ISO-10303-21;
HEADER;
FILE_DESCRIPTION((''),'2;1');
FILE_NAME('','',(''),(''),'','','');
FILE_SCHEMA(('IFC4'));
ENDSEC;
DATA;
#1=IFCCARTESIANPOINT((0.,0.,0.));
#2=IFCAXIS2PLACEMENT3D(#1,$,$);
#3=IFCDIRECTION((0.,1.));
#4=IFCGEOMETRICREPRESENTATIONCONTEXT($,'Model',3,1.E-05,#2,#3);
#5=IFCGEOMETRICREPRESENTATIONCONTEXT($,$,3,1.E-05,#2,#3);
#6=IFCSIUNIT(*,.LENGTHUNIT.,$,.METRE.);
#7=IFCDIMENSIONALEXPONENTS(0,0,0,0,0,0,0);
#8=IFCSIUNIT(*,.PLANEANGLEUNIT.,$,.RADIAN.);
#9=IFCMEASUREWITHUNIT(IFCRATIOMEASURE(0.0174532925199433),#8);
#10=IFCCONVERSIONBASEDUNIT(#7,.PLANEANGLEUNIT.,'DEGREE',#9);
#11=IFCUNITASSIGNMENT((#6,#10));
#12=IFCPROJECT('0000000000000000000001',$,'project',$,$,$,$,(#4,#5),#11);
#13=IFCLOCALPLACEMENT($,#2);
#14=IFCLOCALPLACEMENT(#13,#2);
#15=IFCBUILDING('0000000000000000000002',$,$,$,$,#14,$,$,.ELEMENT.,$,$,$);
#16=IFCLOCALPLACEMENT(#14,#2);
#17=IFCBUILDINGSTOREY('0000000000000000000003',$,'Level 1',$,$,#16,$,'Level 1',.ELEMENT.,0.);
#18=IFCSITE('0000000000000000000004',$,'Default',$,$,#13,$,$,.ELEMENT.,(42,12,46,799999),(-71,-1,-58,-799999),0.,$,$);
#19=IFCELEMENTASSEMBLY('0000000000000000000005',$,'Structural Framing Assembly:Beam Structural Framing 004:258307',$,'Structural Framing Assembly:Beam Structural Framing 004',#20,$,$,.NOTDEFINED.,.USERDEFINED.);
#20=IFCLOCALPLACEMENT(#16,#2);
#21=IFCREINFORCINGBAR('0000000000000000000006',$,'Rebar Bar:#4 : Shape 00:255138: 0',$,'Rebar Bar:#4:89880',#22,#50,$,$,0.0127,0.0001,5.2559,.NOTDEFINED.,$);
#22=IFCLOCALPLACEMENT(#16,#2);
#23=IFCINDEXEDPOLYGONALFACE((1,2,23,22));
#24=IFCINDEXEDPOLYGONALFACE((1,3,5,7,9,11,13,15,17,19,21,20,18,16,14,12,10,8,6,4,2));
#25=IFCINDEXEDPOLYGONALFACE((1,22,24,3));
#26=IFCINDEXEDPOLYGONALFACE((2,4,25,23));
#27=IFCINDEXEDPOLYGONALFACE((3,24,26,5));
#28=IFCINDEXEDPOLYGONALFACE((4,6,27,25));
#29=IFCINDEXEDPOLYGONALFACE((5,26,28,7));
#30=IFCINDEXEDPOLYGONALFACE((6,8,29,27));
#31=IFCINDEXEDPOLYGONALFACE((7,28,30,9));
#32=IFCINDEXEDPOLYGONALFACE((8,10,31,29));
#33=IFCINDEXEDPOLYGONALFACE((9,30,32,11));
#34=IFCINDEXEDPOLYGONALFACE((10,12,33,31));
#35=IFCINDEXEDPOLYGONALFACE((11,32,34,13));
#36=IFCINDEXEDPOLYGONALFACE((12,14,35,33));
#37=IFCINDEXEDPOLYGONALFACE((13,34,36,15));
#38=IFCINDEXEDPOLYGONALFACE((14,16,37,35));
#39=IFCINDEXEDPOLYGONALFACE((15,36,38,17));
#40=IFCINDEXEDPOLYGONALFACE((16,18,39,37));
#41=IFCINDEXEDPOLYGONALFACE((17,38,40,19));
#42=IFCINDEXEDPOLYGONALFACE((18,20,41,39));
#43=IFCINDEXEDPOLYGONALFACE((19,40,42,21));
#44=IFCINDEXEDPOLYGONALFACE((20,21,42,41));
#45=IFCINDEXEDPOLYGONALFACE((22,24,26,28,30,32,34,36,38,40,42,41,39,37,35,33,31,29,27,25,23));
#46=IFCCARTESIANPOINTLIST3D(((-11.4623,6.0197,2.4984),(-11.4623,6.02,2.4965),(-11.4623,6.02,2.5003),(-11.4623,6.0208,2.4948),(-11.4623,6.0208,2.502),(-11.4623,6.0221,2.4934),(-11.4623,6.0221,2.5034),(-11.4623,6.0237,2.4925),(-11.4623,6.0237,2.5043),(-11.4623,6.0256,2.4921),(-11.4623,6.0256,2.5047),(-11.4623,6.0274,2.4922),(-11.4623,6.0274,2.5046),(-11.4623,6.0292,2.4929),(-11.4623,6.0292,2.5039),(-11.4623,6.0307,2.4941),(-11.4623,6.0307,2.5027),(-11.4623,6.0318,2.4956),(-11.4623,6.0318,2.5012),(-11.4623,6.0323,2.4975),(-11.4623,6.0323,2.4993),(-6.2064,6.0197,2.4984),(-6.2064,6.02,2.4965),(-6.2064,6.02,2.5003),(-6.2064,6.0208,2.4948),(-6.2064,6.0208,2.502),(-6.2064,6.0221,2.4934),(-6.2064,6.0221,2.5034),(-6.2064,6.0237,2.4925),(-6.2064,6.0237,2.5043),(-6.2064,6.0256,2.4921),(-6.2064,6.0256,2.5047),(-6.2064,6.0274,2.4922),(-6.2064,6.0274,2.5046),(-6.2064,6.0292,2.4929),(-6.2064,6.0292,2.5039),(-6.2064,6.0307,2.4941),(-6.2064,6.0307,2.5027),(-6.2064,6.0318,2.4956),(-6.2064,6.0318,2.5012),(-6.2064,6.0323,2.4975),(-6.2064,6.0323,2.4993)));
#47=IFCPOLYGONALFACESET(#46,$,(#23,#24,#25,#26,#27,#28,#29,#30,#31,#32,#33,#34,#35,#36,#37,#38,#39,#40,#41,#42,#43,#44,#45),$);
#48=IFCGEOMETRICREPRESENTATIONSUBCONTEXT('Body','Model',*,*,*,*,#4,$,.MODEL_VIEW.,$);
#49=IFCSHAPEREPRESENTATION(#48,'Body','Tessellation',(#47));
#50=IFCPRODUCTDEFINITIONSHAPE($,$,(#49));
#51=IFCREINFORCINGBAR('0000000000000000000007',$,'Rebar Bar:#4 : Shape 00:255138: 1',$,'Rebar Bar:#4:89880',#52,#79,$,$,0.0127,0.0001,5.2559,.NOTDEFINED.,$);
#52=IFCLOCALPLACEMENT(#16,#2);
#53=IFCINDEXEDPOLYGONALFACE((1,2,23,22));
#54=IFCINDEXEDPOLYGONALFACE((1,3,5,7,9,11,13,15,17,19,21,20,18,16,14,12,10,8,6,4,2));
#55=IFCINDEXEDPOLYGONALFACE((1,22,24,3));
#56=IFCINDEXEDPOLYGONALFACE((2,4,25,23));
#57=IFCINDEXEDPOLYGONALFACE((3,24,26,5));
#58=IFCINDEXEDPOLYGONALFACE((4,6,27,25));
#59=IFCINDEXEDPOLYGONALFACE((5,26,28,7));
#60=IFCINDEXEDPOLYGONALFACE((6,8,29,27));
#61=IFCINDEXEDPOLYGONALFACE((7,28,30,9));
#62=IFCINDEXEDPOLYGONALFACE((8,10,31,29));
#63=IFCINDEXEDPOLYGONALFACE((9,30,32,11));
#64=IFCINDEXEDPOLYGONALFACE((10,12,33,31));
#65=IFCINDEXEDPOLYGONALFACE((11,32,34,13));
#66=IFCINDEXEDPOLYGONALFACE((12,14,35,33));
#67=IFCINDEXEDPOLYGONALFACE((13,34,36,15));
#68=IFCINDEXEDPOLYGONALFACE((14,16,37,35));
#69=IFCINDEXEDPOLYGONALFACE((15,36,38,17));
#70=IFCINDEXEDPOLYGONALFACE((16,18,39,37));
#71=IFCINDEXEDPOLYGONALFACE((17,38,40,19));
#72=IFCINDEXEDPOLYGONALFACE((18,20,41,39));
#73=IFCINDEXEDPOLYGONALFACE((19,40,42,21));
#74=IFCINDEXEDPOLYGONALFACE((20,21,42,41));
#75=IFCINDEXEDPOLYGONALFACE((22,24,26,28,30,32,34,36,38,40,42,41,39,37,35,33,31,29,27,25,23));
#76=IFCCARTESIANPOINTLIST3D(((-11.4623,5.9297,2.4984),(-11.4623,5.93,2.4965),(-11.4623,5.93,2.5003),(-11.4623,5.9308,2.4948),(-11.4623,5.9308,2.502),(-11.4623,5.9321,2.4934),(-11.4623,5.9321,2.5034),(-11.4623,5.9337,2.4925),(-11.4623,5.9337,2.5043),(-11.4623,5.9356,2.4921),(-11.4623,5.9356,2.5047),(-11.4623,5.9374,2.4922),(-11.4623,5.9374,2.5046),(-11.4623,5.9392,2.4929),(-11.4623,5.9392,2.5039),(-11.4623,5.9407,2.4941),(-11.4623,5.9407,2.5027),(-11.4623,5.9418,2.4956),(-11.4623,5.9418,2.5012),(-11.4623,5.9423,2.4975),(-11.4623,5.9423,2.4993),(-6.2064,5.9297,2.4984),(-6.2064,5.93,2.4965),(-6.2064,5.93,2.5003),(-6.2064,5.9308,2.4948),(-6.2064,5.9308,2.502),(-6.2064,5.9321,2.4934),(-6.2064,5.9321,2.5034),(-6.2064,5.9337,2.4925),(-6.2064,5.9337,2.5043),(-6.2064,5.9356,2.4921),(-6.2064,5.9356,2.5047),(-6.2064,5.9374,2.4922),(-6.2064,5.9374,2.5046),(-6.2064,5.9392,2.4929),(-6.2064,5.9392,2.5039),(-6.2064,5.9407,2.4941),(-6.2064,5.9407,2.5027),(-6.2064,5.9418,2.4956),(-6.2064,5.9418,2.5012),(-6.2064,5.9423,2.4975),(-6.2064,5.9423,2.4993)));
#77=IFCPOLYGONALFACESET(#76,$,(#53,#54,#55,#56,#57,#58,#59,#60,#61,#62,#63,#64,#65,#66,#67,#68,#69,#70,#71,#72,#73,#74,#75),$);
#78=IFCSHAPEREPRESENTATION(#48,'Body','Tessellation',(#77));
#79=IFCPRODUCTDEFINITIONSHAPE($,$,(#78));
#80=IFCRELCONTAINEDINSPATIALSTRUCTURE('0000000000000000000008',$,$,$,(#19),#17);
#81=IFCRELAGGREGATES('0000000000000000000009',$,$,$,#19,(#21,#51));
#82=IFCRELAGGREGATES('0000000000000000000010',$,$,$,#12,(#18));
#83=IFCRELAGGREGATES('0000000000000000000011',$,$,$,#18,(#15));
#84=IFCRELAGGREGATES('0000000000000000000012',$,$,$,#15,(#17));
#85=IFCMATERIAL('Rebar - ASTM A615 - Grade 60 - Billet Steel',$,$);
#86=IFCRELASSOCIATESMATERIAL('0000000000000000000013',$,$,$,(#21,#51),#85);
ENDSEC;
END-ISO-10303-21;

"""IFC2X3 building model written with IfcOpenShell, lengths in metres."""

from ifc_helpers import new_model, entity, si_unit, converted_unit, direction, origin, place, context, subcontext, project, spatial, material, element, aggregate, save


model = new_model("IFC2X3")

# Units and contexts
model_context = context("Model", 3, precision=1e-05, world=origin(), true_north=direction((0.0, 1.0)))
context_of_model = context(None, 3, precision=1e-05, world=origin(), true_north=direction((0.0, 1.0)))
body_context = subcontext(model_context, "Body", "Model", "MODEL_VIEW")
ifc_project = project(units=[si_unit("LENGTHUNIT", "METRE"), converted_unit("PLANEANGLEUNIT", "DEGREE", entity("IfcRatioMeasure", 0.0174532925199433), si_unit("PLANEANGLEUNIT", "RADIAN"), dimensions=[0, 0, 0, 0, 0, 0, 0])], contexts=[model_context, context_of_model])

# Site, building, storey
site_placement = place(None, origin())
site = spatial("IfcSite", under=ifc_project, at=site_placement, Name="Default", CompositionType="ELEMENT", RefLatitude=(42, 12, 46, 799999), RefLongitude=(-71, -1, -58, -799999), RefElevation=0.0)
building_placement = place(site_placement, origin())
building = spatial("IfcBuilding", under=site, at=building_placement, CompositionType="ELEMENT")
storey_placement = place(building_placement, origin())
storey = spatial("IfcBuildingStorey", under=building, at=storey_placement, Name="Level 1", LongName="Level 1", CompositionType="ELEMENT", Elevation=0.0)

# Element assembly, reinforcing bars
ifc_material = material(Name="Rebar - ASTM A615 - Grade 60 - Billet Steel")
assembly_1_placement = place(storey_placement, origin())
assembly_1 = element("IfcElementAssembly", 1, at=assembly_1_placement, inside=storey, Name="Structural Framing Assembly:Beam Structural Framing 004:258307", ObjectType="Structural Framing Assembly:Beam Structural Framing 004", AssemblyPlace="NOTDEFINED", PredefinedType="USERDEFINED")
reinforcing_bar_1_placement = place(assembly_1_placement, origin())
reinforcing_bar_1 = element("IfcReinforcingBar", 2, at=reinforcing_bar_1_placement, material=ifc_material, Name="Rebar Bar:#4 : Shape 00:255138: 0", ObjectType="Rebar Bar:#4:89880", BarLength=5.2559, BarRole="NOTDEFINED", CrossSectionArea=0.0001, NominalDiameter=0.0127, context=body_context, shape_type="AdvancedSweptSolid", body=[
    entity("IfcSweptDiskSolid", entity("IfcCompositeCurve", [entity("IfcCompositeCurveSegment", "CONTINUOUS", True, entity("IfcPolyline", [entity("IfcCartesianPoint", [-6.2064, 6.026, 2.4984]), entity("IfcCartesianPoint", [-11.4623, 6.026, 2.4984])]))], False), 0.0063, None, 0.0, 1.0),
])
reinforcing_bar_2_placement = place(assembly_1_placement, origin())
reinforcing_bar_2 = element("IfcReinforcingBar", 3, at=reinforcing_bar_2_placement, material=ifc_material, Name="Rebar Bar:#4 : Shape 00:255138: 1", ObjectType="Rebar Bar:#4:89880", BarLength=5.2559, BarRole="NOTDEFINED", CrossSectionArea=0.0001, NominalDiameter=0.0127, context=body_context, shape_type="AdvancedSweptSolid", body=[
    entity("IfcSweptDiskSolid", entity("IfcCompositeCurve", [entity("IfcCompositeCurveSegment", "CONTINUOUS", True, entity("IfcPolyline", [entity("IfcCartesianPoint", [-6.2064, 5.936, 2.4984]), entity("IfcCartesianPoint", [-11.4623, 5.936, 2.4984])]))], False), 0.0063, None, 0.0, 1.0),
])
aggregate(assembly_1, [reinforcing_bar_1, reinforcing_bar_2])

save(model, "model.ifc")
